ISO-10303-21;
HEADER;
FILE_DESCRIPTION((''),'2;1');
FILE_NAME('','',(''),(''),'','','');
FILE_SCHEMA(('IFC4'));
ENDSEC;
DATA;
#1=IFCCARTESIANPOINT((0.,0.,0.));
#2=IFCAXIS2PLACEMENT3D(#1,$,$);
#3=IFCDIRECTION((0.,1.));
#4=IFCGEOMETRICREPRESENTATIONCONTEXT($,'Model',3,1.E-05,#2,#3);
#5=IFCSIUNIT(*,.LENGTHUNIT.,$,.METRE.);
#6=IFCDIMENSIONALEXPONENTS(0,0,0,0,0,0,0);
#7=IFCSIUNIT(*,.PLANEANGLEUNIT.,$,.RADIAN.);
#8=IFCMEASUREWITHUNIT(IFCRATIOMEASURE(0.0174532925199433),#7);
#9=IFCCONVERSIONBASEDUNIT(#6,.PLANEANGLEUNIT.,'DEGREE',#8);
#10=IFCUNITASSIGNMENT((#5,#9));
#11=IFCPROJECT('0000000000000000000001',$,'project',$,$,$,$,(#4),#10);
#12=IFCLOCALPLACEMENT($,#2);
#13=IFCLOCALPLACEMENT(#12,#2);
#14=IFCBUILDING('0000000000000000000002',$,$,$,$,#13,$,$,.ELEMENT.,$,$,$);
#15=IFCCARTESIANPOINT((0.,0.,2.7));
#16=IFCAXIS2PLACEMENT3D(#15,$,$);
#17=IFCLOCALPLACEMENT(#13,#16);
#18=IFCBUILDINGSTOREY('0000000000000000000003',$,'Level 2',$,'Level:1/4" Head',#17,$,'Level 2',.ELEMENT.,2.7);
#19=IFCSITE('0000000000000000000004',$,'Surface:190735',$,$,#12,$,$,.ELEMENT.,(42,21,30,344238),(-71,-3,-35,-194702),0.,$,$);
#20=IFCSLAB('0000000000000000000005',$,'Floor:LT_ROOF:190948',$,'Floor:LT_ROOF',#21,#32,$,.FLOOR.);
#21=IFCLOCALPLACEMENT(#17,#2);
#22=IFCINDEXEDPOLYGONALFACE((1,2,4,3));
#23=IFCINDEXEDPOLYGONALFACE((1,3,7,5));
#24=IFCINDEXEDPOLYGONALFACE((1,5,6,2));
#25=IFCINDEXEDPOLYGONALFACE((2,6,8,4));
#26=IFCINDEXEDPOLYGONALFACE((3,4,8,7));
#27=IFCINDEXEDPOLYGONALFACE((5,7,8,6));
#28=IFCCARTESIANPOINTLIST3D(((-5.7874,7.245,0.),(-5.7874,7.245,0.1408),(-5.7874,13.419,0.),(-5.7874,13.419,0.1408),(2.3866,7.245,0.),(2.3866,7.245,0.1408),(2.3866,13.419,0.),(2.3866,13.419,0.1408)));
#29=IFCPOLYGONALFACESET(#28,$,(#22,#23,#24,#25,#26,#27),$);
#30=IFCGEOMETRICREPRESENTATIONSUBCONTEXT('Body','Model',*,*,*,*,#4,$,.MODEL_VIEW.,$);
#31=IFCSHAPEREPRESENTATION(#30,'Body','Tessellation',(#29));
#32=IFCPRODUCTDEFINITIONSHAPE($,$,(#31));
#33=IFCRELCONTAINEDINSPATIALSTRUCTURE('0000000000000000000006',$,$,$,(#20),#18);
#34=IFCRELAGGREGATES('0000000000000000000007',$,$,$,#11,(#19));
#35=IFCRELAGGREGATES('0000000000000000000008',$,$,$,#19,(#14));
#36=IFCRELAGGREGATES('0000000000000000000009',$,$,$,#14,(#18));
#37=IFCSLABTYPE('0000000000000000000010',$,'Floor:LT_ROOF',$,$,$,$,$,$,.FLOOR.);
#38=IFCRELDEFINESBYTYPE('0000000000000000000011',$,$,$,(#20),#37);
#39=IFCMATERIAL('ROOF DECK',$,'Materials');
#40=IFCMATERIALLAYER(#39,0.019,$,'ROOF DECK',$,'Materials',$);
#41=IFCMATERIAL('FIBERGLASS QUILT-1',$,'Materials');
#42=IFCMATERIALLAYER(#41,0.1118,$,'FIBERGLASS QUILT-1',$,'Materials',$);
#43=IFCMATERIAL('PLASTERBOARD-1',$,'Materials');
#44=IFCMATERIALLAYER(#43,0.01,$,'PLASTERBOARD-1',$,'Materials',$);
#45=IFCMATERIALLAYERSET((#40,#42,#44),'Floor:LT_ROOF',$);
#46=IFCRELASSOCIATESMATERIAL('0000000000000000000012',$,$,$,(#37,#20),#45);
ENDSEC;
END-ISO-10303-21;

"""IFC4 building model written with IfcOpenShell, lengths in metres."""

from ifc_helpers import new_model, entity, si_unit, converted_unit, direction, frame, origin, origin_2d_with_axis, place, context, subcontext, project, spatial, rectangle, extrude, material, layer, layer_set, layer_usage, type_object, element, save


model = new_model("IFC4")

# Units and contexts
model_context = context("Model", 3, precision=1e-05, world=origin(), true_north=direction((0.0, 1.0)))
body_context = subcontext(model_context, "Body", "Model", "MODEL_VIEW")
ifc_project = project(units=[si_unit("LENGTHUNIT", "METRE"), converted_unit("PLANEANGLEUNIT", "DEGREE", entity("IfcRatioMeasure", 0.0174532925199433), si_unit("PLANEANGLEUNIT", "RADIAN"), dimensions=[0, 0, 0, 0, 0, 0, 0])], contexts=[model_context])

# Site, building, storey
site_placement = place(None, origin())
site = spatial("IfcSite", under=ifc_project, at=site_placement, Name="Surface:190735", CompositionType="ELEMENT", RefLatitude=(42, 21, 30, 344238), RefLongitude=(-71, -3, -35, -194702), RefElevation=0.0)
building_placement = place(site_placement, origin())
building = spatial("IfcBuilding", under=site, at=building_placement, CompositionType="ELEMENT")
storey_placement = place(building_placement, frame((0.0, 0.0, 2.7)))
storey = spatial("IfcBuildingStorey", under=building, at=storey_placement, Name="Level 2", ObjectType="Level:1/4\" Head", LongName="Level 2", CompositionType="ELEMENT", Elevation=2.7)

# Slab
ifc_material_1 = material(Name="ROOF DECK", Category="Materials")
ifc_layer_1 = layer(ifc_material_1, 0.019, Name="ROOF DECK", Category="Materials")
ifc_material_2 = material(Name="FIBERGLASS QUILT-1", Category="Materials")
ifc_layer_2 = layer(ifc_material_2, 0.1118, Name="FIBERGLASS QUILT-1", Category="Materials")
ifc_material_3 = material(Name="PLASTERBOARD-1", Category="Materials")
ifc_layer_3 = layer(ifc_material_3, 0.01, Name="PLASTERBOARD-1", Category="Materials")
ifc_layer_set = layer_set([ifc_layer_1, ifc_layer_2, ifc_layer_3], Name="Floor:LT_ROOF")
ifc_layer_usage = layer_usage(ifc_layer_set, "AXIS3", "POSITIVE", 0.0)
slab_type = type_object("IfcSlabType", Name="Floor:LT_ROOF", PredefinedType="FLOOR", material=ifc_layer_set)
slab_placement = place(storey_placement, origin())
element("IfcSlab", 1, at=slab_placement, inside=storey, type_object=slab_type, material=ifc_layer_usage, Name="Floor:LT_ROOF:190948", ObjectType="Floor:LT_ROOF", PredefinedType="FLOOR", context=body_context, shape_type="SweptSolid", body=[
    extrude(rectangle(XDim=6.174, YDim=8.174, at=origin_2d_with_axis()), frame((-1.7004, 10.332, 0.1408), z_axis=(0.0, 0.0, -1.0), x_axis=(0.0, 1.0, 0.0)), (0.0, 0.0, 1.0), 0.1408),
])

save(model, "model.ifc")
